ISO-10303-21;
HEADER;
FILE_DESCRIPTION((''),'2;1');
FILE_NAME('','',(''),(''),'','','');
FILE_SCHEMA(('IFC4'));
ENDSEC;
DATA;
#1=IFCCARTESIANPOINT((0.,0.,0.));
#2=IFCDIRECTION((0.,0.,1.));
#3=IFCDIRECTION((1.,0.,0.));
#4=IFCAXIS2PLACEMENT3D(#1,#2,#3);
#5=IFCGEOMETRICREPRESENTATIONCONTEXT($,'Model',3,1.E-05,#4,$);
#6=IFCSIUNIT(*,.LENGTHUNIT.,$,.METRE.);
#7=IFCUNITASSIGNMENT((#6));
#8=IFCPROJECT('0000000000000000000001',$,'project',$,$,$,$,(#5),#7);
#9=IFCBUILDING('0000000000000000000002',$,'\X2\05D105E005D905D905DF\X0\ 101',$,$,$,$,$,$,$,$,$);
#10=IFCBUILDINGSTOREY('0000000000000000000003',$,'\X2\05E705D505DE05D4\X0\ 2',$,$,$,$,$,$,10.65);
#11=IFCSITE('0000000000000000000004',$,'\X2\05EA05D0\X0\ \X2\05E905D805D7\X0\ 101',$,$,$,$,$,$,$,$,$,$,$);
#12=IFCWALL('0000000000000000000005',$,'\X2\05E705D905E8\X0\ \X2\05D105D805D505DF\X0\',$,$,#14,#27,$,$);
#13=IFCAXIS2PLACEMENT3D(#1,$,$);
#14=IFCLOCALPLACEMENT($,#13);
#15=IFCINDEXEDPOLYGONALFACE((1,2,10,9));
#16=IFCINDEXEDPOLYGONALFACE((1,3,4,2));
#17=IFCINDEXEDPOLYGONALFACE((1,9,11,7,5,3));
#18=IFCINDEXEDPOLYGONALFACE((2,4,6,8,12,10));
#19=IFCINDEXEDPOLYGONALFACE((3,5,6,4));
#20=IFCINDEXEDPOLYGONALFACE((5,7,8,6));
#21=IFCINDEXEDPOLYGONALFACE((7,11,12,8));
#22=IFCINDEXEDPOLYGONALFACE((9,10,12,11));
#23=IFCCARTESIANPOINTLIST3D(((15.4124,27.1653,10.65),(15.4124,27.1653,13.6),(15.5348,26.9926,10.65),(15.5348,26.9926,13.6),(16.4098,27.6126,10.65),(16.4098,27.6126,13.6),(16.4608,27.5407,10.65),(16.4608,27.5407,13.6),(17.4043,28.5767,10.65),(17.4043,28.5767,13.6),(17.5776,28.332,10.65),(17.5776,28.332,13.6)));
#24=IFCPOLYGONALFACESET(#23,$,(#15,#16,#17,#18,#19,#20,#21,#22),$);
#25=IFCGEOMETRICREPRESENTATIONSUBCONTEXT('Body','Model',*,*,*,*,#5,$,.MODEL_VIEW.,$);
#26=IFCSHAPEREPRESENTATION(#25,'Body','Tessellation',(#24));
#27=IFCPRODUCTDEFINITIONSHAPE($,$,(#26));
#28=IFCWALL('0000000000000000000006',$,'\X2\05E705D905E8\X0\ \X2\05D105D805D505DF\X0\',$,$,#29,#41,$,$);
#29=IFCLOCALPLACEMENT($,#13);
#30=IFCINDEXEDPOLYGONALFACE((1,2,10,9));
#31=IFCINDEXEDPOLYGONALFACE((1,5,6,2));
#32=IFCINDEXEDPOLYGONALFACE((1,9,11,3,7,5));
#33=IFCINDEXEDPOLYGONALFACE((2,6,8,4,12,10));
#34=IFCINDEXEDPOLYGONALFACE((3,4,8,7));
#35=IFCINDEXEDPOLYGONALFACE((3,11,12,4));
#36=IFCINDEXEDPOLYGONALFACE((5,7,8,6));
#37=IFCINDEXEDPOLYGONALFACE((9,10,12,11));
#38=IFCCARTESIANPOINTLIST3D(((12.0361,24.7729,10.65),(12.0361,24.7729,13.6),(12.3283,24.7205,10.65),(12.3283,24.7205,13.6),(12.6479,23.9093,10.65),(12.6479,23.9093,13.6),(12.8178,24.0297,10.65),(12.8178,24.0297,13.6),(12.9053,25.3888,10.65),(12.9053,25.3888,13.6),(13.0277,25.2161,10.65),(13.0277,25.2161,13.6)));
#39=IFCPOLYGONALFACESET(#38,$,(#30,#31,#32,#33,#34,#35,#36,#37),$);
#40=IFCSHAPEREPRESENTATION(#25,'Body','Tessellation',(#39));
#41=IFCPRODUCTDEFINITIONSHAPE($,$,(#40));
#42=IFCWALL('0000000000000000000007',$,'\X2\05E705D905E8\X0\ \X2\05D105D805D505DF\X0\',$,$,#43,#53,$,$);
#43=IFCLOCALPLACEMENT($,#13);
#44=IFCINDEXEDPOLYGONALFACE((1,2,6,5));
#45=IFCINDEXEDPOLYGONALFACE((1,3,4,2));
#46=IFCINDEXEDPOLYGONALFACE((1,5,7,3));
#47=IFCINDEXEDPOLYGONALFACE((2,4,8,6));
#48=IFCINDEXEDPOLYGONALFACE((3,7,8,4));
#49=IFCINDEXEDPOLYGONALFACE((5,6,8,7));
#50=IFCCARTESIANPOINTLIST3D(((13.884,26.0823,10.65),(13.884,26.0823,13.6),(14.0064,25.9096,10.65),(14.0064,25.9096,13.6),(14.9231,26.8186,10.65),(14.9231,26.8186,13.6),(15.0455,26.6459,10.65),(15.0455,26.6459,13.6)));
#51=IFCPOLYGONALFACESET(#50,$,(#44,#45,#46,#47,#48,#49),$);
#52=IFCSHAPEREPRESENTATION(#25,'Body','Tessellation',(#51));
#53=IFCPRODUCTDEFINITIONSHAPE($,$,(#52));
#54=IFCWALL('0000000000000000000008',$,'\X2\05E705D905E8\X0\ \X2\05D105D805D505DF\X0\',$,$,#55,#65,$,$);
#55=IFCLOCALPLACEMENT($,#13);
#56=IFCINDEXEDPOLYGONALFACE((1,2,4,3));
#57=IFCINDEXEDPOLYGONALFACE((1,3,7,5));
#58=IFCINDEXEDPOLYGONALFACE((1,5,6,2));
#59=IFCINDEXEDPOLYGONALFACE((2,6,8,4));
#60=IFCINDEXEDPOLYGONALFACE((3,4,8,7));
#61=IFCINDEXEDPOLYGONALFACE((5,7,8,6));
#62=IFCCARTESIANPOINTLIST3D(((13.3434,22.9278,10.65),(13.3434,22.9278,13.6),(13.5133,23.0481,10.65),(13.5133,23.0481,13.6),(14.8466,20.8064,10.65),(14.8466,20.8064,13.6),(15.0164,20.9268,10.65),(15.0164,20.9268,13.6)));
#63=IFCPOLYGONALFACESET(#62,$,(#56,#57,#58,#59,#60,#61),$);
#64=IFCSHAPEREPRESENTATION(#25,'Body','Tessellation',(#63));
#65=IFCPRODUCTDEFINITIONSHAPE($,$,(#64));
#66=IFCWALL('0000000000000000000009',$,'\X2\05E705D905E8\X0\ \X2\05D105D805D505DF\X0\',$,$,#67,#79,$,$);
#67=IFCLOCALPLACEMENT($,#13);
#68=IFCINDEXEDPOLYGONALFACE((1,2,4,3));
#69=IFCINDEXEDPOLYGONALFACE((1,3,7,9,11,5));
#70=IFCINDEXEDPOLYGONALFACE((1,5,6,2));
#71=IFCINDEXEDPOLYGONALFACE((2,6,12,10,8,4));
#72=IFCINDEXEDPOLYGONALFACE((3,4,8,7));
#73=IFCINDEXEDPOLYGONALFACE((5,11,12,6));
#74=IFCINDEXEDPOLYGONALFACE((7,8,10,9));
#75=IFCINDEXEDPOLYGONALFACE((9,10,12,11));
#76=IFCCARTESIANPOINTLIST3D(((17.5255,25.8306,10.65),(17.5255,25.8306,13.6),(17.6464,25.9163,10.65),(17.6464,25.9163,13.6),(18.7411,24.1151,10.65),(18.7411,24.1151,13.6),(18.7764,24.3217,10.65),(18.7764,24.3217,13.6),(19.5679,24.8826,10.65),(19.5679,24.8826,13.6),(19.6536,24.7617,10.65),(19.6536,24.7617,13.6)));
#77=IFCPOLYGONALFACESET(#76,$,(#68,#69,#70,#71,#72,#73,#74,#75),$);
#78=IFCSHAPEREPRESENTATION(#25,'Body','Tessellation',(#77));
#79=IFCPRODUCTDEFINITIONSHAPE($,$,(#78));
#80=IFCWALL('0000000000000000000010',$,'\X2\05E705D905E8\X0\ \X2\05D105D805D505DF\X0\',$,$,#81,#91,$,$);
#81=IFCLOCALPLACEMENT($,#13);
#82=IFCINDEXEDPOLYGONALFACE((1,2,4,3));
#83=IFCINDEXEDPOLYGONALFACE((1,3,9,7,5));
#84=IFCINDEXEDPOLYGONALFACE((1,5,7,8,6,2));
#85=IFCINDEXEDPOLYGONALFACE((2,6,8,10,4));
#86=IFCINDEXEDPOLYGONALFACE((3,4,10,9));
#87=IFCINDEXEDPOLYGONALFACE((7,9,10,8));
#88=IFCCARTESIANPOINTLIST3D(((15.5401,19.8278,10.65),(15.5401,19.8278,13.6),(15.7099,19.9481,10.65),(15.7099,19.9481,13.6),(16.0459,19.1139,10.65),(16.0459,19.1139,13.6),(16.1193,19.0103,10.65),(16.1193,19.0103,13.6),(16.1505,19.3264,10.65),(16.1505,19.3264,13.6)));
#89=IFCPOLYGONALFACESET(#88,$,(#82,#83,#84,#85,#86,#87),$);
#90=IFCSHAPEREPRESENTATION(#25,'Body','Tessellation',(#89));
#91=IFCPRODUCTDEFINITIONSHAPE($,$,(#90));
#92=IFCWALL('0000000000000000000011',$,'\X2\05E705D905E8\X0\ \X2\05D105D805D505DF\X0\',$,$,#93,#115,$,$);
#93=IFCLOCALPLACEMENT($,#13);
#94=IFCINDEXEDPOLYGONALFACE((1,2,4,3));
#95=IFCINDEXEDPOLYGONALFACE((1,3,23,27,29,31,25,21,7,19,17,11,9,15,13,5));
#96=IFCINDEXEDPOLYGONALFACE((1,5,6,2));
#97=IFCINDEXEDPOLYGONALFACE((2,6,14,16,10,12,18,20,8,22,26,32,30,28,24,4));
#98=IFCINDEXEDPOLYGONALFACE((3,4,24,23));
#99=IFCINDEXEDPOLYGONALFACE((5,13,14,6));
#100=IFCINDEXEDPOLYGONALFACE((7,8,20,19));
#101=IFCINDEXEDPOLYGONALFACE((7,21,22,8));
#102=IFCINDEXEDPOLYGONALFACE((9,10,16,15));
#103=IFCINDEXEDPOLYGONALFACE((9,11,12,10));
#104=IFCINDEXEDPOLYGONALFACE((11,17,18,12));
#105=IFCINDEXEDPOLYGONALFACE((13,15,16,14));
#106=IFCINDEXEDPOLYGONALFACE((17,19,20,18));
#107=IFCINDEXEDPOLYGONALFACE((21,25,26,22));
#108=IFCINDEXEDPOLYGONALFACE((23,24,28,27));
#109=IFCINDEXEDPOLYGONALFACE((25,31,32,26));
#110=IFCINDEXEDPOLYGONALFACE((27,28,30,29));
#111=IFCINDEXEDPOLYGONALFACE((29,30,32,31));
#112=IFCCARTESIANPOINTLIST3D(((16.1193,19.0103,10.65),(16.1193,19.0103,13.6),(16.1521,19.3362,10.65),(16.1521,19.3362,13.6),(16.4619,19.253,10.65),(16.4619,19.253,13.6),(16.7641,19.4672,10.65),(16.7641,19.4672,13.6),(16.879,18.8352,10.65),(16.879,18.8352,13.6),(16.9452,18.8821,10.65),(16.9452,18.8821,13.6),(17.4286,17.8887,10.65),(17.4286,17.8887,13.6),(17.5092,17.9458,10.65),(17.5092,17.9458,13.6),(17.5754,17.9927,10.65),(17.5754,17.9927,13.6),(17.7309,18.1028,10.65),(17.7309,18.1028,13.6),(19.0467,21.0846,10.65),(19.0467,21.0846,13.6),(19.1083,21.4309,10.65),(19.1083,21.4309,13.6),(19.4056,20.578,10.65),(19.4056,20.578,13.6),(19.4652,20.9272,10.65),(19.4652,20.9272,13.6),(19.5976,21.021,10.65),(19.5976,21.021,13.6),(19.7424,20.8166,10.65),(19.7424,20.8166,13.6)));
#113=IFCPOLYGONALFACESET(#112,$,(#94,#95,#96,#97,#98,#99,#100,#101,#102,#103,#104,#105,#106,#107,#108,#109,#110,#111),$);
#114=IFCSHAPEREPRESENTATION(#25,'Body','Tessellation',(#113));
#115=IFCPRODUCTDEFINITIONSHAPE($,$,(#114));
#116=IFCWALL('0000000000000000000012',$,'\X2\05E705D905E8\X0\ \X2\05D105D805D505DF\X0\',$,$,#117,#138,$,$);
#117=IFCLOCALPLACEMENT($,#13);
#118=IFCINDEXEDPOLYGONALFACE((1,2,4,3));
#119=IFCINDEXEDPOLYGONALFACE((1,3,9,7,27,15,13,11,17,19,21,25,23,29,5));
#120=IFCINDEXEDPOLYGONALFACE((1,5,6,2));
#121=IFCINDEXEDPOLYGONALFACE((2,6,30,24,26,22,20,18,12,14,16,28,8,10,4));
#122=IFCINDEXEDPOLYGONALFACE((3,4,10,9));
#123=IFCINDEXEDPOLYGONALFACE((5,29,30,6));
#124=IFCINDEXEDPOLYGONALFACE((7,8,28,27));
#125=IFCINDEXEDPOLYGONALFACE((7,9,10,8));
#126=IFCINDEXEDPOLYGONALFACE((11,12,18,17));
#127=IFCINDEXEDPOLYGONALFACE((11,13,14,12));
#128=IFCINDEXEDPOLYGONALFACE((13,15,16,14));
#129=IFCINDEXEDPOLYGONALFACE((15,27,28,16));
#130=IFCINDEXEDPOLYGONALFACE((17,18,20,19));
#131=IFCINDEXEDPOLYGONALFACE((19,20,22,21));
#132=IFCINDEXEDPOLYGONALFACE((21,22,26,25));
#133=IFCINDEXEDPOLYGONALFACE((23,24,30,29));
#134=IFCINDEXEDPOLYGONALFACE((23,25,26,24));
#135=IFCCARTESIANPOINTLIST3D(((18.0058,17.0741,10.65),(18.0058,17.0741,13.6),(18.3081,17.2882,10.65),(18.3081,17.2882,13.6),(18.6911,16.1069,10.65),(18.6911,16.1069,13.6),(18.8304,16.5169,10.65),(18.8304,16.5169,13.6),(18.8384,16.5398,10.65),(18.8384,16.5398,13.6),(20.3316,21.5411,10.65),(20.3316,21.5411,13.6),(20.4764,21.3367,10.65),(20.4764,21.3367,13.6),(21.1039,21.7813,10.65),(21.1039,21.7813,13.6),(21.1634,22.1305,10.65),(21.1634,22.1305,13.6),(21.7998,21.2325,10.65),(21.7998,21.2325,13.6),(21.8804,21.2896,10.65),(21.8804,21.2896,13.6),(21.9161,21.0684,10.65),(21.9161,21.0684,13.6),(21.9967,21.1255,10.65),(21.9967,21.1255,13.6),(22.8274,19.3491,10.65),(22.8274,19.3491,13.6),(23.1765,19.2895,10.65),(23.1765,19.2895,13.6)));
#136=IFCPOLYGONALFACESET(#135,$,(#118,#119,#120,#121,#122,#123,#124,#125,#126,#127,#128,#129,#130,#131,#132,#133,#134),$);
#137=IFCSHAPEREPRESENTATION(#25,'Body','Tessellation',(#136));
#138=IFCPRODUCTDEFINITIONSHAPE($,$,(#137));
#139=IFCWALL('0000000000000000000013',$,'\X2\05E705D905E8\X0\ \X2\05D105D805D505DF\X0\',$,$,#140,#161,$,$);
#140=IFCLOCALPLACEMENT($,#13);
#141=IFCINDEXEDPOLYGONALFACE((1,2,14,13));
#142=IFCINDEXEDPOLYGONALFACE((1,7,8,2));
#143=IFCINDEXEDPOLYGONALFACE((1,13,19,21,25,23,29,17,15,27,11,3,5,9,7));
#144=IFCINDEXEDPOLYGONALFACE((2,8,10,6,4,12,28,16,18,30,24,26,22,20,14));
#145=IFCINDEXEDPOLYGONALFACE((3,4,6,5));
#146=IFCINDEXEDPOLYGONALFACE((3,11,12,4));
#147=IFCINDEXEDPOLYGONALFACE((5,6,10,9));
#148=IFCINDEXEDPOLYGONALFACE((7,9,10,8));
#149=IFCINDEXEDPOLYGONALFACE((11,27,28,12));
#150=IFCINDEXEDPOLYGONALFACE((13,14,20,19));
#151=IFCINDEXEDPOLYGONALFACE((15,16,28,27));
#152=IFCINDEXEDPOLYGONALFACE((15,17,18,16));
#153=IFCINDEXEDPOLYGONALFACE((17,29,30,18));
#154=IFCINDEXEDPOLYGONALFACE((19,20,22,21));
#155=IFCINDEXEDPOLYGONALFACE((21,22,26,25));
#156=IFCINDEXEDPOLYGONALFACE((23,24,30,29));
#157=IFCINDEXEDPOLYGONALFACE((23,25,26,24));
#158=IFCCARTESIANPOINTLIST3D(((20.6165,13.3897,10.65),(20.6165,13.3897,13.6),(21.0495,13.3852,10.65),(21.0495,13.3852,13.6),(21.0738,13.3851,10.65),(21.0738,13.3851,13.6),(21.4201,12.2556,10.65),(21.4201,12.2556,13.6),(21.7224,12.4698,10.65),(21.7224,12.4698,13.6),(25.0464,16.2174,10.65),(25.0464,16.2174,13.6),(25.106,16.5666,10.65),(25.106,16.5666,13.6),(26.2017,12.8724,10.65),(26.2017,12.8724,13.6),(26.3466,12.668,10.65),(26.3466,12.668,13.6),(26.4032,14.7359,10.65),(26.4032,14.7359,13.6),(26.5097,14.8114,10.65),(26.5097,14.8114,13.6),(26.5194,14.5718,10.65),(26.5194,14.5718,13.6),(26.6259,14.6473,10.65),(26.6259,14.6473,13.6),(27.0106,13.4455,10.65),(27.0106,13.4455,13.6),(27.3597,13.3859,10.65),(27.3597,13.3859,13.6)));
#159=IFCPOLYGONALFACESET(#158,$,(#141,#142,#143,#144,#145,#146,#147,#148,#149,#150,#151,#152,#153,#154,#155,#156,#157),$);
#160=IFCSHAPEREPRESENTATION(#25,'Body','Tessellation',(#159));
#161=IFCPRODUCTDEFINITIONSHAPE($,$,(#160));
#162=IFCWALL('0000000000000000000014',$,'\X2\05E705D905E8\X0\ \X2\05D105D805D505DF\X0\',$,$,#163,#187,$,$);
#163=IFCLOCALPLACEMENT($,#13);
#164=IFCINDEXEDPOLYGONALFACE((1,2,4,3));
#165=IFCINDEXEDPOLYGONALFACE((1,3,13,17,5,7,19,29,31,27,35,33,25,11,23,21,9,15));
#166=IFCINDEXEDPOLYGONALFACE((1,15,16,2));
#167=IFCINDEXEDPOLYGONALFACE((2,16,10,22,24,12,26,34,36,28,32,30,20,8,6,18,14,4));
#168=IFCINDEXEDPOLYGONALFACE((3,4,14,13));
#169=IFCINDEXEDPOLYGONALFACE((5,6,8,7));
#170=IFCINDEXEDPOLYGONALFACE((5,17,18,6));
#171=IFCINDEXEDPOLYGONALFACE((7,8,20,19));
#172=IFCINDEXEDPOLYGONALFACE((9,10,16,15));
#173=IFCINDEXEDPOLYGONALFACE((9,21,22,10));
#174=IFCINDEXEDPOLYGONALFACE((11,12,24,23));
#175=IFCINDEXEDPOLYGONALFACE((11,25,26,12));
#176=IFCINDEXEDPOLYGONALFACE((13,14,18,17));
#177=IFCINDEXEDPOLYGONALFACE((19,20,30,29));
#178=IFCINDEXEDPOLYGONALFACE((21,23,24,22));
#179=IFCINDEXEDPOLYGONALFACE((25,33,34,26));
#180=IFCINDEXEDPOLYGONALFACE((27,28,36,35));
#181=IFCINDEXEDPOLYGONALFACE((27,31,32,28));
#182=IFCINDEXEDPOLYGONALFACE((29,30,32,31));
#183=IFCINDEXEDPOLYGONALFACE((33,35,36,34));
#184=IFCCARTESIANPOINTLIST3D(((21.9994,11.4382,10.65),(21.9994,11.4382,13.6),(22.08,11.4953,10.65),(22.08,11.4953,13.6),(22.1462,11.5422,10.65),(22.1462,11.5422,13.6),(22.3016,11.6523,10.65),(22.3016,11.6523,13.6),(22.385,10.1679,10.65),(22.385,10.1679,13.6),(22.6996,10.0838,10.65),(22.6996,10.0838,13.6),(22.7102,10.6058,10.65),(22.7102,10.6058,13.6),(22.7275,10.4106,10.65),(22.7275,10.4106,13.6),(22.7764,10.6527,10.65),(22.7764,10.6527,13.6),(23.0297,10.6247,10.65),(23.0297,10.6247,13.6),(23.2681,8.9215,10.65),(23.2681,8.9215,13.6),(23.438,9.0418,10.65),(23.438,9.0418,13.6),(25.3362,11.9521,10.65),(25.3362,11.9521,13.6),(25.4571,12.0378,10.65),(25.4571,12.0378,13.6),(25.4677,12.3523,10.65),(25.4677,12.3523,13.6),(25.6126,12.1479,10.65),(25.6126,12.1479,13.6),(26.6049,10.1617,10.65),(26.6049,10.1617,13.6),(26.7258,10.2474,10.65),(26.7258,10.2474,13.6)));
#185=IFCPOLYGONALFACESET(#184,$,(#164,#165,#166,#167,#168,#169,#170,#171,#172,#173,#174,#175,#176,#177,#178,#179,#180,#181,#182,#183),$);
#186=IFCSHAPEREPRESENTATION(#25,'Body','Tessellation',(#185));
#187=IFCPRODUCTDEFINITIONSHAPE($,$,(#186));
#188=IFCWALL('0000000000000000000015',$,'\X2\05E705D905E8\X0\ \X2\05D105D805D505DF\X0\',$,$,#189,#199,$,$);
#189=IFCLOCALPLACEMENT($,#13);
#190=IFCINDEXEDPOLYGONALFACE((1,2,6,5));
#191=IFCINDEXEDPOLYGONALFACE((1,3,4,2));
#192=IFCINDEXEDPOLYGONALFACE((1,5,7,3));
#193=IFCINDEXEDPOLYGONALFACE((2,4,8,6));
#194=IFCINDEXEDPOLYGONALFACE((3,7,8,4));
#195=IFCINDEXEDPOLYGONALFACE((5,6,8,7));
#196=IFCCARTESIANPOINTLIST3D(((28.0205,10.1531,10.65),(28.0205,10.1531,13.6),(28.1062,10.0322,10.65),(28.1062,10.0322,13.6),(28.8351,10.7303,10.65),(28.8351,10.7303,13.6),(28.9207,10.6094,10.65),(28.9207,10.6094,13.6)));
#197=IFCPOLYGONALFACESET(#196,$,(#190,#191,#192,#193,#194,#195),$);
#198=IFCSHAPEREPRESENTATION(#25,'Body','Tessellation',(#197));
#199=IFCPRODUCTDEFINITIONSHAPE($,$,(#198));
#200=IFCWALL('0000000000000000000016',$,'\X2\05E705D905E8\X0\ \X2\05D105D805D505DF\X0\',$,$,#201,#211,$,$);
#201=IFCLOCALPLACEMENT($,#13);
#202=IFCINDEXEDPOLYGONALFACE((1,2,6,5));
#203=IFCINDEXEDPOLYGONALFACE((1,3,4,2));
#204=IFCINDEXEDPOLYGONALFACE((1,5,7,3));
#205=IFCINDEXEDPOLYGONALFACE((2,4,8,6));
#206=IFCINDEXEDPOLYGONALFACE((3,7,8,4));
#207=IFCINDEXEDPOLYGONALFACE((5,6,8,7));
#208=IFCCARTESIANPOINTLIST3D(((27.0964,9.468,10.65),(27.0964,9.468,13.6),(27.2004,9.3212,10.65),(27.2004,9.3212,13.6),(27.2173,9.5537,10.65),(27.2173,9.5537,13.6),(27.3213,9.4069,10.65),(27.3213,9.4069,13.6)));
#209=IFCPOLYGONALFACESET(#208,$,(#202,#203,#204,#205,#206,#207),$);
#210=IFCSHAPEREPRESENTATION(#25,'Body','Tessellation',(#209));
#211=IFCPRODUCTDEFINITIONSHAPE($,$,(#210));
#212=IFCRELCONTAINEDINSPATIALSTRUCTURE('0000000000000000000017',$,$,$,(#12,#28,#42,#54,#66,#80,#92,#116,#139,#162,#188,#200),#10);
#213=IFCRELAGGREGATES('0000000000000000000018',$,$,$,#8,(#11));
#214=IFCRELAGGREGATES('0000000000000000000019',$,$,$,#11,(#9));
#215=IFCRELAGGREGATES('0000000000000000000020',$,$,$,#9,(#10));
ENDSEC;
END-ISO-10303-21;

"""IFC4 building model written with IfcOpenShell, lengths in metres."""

from ifc_helpers import new_model, si_unit, frame, origin_with_axes, context, subcontext, project, spatial, polyline, outline, extrude, element, save


model = new_model("IFC4")

# Units and contexts
model_context = context("Model", 3, precision=1e-05, world=origin_with_axes())
body_context = subcontext(model_context, "Body", "Model", "MODEL_VIEW")
ifc_project = project(units=[si_unit("LENGTHUNIT", "METRE")], contexts=[model_context])

# Site, building, storey
site = spatial("IfcSite", under=ifc_project, Name="תא שטח 101")
building = spatial("IfcBuilding", under=site, Name="בניין 101")
storey = spatial("IfcBuildingStorey", under=building, Name="קומה 2", Elevation=10.65)

# Walls
element("IfcWall", 1, inside=storey, Name="קיר בטון", context=body_context, shape_type="SweptSolid", body=[
    extrude(outline(polyline([(15.5348, 26.9926), (16.4098, 27.6126), (16.4608, 27.5407), (17.5776, 28.332), (17.4043, 28.5767), (15.4124, 27.1653), (15.5348, 26.9926)])), frame((0.0, 0.0, 10.65)), (0.0, 0.0, 1.0), 2.95),
])
element("IfcWall", 2, inside=storey, Name="קיר בטון", context=body_context, shape_type="SweptSolid", body=[
    extrude(outline(polyline([(12.3283, 24.7205), (13.0277, 25.2161), (12.9053, 25.3888), (12.0361, 24.7729), (12.6479, 23.9093), (12.8178, 24.0297), (12.3283, 24.7205)])), frame((0.0, 0.0, 10.65)), (0.0, 0.0, 1.0), 2.95),
])
element("IfcWall", 3, inside=storey, Name="קיר בטון", context=body_context, shape_type="SweptSolid", body=[
    extrude(outline(polyline([(14.9231, 26.8186), (13.884, 26.0823), (14.0064, 25.9096), (15.0455, 26.6459), (14.9231, 26.8186)])), frame((0.0, 0.0, 10.65)), (0.0, 0.0, 1.0), 2.95),
])
element("IfcWall", 4, inside=storey, Name="קיר בטון", context=body_context, shape_type="SweptSolid", body=[
    extrude(outline(polyline([(14.8466, 20.8064), (15.0164, 20.9268), (13.5133, 23.0481), (13.3434, 22.9278), (14.8466, 20.8064)])), frame((0.0, 0.0, 10.65)), (0.0, 0.0, 1.0), 2.95),
])
element("IfcWall", 5, inside=storey, Name="קיר בטון", context=body_context, shape_type="SweptSolid", body=[
    extrude(outline(polyline([(18.7411, 24.1151), (19.6536, 24.7617), (19.5679, 24.8826), (18.7764, 24.3217), (17.6464, 25.9163), (17.5255, 25.8306), (18.7411, 24.1151)])), frame((0.0, 0.0, 10.65)), (0.0, 0.0, 1.0), 2.95),
])
element("IfcWall", 6, inside=storey, Name="קיר בטון", context=body_context, shape_type="SweptSolid", body=[
    extrude(outline(polyline([(15.5401, 19.8278), (16.0459, 19.1139), (16.1193, 19.0103), (16.1505, 19.3264), (15.7099, 19.9481), (15.5401, 19.8278)])), frame((0.0, 0.0, 10.65)), (0.0, 0.0, 1.0), 2.95),
])
element("IfcWall", 7, inside=storey, Name="קיר בטון", context=body_context, shape_type="SweptSolid", body=[
    extrude(outline(polyline([(19.7424, 20.8166), (19.5976, 21.021), (19.4652, 20.9272), (19.1083, 21.4309), (16.1521, 19.3362), (16.1193, 19.0103), (16.4619, 19.253), (17.4286, 17.8887), (17.5092, 17.9458), (16.879, 18.8352), (16.9452, 18.8821), (17.5754, 17.9927), (17.7309, 18.1028), (16.7641, 19.4672), (19.0467, 21.0846), (19.4056, 20.578), (19.7424, 20.8166)])), frame((0.0, 0.0, 10.65)), (0.0, 0.0, 1.0), 2.95),
])
element("IfcWall", 8, inside=storey, Name="קיר בטון", context=body_context, shape_type="SweptSolid", body=[
    extrude(outline(polyline([(20.3316, 21.5411), (20.4764, 21.3367), (21.1039, 21.7813), (22.8274, 19.3491), (18.8293, 16.5161), (18.7235, 16.2077), (18.8384, 16.5398), (18.3081, 17.2882), (18.0058, 17.0741), (18.6911, 16.1069), (23.1765, 19.2895), (21.9161, 21.0684), (21.9967, 21.1255), (21.8804, 21.2896), (21.7998, 21.2325), (21.8875, 21.1087), (21.1634, 22.1305), (20.3316, 21.5411)])), frame((0.0, 0.0, 10.65)), (0.0, 0.0, 1.0), 2.95),
])
element("IfcWall", 9, inside=storey, Name="קיר בטון", context=body_context, shape_type="SweptSolid", body=[
    extrude(outline(polyline([(21.7224, 12.4698), (21.0738, 13.3851), (20.922, 13.3857), (21.0483, 13.3844), (25.0464, 16.2174), (27.0106, 13.4455), (26.2017, 12.8724), (26.3466, 12.668), (27.3597, 13.3859), (26.5194, 14.5718), (26.6259, 14.6473), (26.5097, 14.8114), (26.4032, 14.7359), (25.106, 16.5666), (20.6165, 13.3897), (21.4201, 12.2556), (21.7224, 12.4698)])), frame((0.0, 0.0, 10.65)), (0.0, 0.0, 1.0), 2.95),
])
element("IfcWall", 10, inside=storey, Name="קיר בטון", context=body_context, shape_type="SweptSolid", body=[
    extrude(outline(polyline([(22.7275, 10.4106), (22.385, 10.1679), (23.2681, 8.9215), (23.438, 9.0418), (22.6996, 10.0838), (25.3362, 11.9521), (26.6049, 10.1617), (26.7258, 10.2474), (25.4571, 12.0378), (25.6126, 12.1479), (25.4677, 12.3523), (23.0297, 10.6247), (22.3016, 11.6523), (22.1462, 11.5422), (22.7764, 10.6527), (22.7102, 10.6058), (22.08, 11.4953), (21.9994, 11.4382), (22.7275, 10.4106)])), frame((0.0, 0.0, 10.65)), (0.0, 0.0, 1.0), 2.95),
])
element("IfcWall", 11, inside=storey, Name="קיר בטון", context=body_context, shape_type="SweptSolid", body=[
    extrude(outline(polyline([(28.0205, 10.1531), (28.1062, 10.0322), (28.9207, 10.6094), (28.8351, 10.7303), (28.0205, 10.1531)])), frame((0.0, 0.0, 10.65)), (0.0, 0.0, 1.0), 2.95),
])
element("IfcWall", 12, inside=storey, Name="קיר בטון", context=body_context, shape_type="SweptSolid", body=[
    extrude(outline(polyline([(27.2173, 9.5537), (27.0964, 9.468), (27.2004, 9.3212), (27.3213, 9.4069), (27.2173, 9.5537)])), frame((0.0, 0.0, 10.65)), (0.0, 0.0, 1.0), 2.95),
])

save(model, "model.ifc")
